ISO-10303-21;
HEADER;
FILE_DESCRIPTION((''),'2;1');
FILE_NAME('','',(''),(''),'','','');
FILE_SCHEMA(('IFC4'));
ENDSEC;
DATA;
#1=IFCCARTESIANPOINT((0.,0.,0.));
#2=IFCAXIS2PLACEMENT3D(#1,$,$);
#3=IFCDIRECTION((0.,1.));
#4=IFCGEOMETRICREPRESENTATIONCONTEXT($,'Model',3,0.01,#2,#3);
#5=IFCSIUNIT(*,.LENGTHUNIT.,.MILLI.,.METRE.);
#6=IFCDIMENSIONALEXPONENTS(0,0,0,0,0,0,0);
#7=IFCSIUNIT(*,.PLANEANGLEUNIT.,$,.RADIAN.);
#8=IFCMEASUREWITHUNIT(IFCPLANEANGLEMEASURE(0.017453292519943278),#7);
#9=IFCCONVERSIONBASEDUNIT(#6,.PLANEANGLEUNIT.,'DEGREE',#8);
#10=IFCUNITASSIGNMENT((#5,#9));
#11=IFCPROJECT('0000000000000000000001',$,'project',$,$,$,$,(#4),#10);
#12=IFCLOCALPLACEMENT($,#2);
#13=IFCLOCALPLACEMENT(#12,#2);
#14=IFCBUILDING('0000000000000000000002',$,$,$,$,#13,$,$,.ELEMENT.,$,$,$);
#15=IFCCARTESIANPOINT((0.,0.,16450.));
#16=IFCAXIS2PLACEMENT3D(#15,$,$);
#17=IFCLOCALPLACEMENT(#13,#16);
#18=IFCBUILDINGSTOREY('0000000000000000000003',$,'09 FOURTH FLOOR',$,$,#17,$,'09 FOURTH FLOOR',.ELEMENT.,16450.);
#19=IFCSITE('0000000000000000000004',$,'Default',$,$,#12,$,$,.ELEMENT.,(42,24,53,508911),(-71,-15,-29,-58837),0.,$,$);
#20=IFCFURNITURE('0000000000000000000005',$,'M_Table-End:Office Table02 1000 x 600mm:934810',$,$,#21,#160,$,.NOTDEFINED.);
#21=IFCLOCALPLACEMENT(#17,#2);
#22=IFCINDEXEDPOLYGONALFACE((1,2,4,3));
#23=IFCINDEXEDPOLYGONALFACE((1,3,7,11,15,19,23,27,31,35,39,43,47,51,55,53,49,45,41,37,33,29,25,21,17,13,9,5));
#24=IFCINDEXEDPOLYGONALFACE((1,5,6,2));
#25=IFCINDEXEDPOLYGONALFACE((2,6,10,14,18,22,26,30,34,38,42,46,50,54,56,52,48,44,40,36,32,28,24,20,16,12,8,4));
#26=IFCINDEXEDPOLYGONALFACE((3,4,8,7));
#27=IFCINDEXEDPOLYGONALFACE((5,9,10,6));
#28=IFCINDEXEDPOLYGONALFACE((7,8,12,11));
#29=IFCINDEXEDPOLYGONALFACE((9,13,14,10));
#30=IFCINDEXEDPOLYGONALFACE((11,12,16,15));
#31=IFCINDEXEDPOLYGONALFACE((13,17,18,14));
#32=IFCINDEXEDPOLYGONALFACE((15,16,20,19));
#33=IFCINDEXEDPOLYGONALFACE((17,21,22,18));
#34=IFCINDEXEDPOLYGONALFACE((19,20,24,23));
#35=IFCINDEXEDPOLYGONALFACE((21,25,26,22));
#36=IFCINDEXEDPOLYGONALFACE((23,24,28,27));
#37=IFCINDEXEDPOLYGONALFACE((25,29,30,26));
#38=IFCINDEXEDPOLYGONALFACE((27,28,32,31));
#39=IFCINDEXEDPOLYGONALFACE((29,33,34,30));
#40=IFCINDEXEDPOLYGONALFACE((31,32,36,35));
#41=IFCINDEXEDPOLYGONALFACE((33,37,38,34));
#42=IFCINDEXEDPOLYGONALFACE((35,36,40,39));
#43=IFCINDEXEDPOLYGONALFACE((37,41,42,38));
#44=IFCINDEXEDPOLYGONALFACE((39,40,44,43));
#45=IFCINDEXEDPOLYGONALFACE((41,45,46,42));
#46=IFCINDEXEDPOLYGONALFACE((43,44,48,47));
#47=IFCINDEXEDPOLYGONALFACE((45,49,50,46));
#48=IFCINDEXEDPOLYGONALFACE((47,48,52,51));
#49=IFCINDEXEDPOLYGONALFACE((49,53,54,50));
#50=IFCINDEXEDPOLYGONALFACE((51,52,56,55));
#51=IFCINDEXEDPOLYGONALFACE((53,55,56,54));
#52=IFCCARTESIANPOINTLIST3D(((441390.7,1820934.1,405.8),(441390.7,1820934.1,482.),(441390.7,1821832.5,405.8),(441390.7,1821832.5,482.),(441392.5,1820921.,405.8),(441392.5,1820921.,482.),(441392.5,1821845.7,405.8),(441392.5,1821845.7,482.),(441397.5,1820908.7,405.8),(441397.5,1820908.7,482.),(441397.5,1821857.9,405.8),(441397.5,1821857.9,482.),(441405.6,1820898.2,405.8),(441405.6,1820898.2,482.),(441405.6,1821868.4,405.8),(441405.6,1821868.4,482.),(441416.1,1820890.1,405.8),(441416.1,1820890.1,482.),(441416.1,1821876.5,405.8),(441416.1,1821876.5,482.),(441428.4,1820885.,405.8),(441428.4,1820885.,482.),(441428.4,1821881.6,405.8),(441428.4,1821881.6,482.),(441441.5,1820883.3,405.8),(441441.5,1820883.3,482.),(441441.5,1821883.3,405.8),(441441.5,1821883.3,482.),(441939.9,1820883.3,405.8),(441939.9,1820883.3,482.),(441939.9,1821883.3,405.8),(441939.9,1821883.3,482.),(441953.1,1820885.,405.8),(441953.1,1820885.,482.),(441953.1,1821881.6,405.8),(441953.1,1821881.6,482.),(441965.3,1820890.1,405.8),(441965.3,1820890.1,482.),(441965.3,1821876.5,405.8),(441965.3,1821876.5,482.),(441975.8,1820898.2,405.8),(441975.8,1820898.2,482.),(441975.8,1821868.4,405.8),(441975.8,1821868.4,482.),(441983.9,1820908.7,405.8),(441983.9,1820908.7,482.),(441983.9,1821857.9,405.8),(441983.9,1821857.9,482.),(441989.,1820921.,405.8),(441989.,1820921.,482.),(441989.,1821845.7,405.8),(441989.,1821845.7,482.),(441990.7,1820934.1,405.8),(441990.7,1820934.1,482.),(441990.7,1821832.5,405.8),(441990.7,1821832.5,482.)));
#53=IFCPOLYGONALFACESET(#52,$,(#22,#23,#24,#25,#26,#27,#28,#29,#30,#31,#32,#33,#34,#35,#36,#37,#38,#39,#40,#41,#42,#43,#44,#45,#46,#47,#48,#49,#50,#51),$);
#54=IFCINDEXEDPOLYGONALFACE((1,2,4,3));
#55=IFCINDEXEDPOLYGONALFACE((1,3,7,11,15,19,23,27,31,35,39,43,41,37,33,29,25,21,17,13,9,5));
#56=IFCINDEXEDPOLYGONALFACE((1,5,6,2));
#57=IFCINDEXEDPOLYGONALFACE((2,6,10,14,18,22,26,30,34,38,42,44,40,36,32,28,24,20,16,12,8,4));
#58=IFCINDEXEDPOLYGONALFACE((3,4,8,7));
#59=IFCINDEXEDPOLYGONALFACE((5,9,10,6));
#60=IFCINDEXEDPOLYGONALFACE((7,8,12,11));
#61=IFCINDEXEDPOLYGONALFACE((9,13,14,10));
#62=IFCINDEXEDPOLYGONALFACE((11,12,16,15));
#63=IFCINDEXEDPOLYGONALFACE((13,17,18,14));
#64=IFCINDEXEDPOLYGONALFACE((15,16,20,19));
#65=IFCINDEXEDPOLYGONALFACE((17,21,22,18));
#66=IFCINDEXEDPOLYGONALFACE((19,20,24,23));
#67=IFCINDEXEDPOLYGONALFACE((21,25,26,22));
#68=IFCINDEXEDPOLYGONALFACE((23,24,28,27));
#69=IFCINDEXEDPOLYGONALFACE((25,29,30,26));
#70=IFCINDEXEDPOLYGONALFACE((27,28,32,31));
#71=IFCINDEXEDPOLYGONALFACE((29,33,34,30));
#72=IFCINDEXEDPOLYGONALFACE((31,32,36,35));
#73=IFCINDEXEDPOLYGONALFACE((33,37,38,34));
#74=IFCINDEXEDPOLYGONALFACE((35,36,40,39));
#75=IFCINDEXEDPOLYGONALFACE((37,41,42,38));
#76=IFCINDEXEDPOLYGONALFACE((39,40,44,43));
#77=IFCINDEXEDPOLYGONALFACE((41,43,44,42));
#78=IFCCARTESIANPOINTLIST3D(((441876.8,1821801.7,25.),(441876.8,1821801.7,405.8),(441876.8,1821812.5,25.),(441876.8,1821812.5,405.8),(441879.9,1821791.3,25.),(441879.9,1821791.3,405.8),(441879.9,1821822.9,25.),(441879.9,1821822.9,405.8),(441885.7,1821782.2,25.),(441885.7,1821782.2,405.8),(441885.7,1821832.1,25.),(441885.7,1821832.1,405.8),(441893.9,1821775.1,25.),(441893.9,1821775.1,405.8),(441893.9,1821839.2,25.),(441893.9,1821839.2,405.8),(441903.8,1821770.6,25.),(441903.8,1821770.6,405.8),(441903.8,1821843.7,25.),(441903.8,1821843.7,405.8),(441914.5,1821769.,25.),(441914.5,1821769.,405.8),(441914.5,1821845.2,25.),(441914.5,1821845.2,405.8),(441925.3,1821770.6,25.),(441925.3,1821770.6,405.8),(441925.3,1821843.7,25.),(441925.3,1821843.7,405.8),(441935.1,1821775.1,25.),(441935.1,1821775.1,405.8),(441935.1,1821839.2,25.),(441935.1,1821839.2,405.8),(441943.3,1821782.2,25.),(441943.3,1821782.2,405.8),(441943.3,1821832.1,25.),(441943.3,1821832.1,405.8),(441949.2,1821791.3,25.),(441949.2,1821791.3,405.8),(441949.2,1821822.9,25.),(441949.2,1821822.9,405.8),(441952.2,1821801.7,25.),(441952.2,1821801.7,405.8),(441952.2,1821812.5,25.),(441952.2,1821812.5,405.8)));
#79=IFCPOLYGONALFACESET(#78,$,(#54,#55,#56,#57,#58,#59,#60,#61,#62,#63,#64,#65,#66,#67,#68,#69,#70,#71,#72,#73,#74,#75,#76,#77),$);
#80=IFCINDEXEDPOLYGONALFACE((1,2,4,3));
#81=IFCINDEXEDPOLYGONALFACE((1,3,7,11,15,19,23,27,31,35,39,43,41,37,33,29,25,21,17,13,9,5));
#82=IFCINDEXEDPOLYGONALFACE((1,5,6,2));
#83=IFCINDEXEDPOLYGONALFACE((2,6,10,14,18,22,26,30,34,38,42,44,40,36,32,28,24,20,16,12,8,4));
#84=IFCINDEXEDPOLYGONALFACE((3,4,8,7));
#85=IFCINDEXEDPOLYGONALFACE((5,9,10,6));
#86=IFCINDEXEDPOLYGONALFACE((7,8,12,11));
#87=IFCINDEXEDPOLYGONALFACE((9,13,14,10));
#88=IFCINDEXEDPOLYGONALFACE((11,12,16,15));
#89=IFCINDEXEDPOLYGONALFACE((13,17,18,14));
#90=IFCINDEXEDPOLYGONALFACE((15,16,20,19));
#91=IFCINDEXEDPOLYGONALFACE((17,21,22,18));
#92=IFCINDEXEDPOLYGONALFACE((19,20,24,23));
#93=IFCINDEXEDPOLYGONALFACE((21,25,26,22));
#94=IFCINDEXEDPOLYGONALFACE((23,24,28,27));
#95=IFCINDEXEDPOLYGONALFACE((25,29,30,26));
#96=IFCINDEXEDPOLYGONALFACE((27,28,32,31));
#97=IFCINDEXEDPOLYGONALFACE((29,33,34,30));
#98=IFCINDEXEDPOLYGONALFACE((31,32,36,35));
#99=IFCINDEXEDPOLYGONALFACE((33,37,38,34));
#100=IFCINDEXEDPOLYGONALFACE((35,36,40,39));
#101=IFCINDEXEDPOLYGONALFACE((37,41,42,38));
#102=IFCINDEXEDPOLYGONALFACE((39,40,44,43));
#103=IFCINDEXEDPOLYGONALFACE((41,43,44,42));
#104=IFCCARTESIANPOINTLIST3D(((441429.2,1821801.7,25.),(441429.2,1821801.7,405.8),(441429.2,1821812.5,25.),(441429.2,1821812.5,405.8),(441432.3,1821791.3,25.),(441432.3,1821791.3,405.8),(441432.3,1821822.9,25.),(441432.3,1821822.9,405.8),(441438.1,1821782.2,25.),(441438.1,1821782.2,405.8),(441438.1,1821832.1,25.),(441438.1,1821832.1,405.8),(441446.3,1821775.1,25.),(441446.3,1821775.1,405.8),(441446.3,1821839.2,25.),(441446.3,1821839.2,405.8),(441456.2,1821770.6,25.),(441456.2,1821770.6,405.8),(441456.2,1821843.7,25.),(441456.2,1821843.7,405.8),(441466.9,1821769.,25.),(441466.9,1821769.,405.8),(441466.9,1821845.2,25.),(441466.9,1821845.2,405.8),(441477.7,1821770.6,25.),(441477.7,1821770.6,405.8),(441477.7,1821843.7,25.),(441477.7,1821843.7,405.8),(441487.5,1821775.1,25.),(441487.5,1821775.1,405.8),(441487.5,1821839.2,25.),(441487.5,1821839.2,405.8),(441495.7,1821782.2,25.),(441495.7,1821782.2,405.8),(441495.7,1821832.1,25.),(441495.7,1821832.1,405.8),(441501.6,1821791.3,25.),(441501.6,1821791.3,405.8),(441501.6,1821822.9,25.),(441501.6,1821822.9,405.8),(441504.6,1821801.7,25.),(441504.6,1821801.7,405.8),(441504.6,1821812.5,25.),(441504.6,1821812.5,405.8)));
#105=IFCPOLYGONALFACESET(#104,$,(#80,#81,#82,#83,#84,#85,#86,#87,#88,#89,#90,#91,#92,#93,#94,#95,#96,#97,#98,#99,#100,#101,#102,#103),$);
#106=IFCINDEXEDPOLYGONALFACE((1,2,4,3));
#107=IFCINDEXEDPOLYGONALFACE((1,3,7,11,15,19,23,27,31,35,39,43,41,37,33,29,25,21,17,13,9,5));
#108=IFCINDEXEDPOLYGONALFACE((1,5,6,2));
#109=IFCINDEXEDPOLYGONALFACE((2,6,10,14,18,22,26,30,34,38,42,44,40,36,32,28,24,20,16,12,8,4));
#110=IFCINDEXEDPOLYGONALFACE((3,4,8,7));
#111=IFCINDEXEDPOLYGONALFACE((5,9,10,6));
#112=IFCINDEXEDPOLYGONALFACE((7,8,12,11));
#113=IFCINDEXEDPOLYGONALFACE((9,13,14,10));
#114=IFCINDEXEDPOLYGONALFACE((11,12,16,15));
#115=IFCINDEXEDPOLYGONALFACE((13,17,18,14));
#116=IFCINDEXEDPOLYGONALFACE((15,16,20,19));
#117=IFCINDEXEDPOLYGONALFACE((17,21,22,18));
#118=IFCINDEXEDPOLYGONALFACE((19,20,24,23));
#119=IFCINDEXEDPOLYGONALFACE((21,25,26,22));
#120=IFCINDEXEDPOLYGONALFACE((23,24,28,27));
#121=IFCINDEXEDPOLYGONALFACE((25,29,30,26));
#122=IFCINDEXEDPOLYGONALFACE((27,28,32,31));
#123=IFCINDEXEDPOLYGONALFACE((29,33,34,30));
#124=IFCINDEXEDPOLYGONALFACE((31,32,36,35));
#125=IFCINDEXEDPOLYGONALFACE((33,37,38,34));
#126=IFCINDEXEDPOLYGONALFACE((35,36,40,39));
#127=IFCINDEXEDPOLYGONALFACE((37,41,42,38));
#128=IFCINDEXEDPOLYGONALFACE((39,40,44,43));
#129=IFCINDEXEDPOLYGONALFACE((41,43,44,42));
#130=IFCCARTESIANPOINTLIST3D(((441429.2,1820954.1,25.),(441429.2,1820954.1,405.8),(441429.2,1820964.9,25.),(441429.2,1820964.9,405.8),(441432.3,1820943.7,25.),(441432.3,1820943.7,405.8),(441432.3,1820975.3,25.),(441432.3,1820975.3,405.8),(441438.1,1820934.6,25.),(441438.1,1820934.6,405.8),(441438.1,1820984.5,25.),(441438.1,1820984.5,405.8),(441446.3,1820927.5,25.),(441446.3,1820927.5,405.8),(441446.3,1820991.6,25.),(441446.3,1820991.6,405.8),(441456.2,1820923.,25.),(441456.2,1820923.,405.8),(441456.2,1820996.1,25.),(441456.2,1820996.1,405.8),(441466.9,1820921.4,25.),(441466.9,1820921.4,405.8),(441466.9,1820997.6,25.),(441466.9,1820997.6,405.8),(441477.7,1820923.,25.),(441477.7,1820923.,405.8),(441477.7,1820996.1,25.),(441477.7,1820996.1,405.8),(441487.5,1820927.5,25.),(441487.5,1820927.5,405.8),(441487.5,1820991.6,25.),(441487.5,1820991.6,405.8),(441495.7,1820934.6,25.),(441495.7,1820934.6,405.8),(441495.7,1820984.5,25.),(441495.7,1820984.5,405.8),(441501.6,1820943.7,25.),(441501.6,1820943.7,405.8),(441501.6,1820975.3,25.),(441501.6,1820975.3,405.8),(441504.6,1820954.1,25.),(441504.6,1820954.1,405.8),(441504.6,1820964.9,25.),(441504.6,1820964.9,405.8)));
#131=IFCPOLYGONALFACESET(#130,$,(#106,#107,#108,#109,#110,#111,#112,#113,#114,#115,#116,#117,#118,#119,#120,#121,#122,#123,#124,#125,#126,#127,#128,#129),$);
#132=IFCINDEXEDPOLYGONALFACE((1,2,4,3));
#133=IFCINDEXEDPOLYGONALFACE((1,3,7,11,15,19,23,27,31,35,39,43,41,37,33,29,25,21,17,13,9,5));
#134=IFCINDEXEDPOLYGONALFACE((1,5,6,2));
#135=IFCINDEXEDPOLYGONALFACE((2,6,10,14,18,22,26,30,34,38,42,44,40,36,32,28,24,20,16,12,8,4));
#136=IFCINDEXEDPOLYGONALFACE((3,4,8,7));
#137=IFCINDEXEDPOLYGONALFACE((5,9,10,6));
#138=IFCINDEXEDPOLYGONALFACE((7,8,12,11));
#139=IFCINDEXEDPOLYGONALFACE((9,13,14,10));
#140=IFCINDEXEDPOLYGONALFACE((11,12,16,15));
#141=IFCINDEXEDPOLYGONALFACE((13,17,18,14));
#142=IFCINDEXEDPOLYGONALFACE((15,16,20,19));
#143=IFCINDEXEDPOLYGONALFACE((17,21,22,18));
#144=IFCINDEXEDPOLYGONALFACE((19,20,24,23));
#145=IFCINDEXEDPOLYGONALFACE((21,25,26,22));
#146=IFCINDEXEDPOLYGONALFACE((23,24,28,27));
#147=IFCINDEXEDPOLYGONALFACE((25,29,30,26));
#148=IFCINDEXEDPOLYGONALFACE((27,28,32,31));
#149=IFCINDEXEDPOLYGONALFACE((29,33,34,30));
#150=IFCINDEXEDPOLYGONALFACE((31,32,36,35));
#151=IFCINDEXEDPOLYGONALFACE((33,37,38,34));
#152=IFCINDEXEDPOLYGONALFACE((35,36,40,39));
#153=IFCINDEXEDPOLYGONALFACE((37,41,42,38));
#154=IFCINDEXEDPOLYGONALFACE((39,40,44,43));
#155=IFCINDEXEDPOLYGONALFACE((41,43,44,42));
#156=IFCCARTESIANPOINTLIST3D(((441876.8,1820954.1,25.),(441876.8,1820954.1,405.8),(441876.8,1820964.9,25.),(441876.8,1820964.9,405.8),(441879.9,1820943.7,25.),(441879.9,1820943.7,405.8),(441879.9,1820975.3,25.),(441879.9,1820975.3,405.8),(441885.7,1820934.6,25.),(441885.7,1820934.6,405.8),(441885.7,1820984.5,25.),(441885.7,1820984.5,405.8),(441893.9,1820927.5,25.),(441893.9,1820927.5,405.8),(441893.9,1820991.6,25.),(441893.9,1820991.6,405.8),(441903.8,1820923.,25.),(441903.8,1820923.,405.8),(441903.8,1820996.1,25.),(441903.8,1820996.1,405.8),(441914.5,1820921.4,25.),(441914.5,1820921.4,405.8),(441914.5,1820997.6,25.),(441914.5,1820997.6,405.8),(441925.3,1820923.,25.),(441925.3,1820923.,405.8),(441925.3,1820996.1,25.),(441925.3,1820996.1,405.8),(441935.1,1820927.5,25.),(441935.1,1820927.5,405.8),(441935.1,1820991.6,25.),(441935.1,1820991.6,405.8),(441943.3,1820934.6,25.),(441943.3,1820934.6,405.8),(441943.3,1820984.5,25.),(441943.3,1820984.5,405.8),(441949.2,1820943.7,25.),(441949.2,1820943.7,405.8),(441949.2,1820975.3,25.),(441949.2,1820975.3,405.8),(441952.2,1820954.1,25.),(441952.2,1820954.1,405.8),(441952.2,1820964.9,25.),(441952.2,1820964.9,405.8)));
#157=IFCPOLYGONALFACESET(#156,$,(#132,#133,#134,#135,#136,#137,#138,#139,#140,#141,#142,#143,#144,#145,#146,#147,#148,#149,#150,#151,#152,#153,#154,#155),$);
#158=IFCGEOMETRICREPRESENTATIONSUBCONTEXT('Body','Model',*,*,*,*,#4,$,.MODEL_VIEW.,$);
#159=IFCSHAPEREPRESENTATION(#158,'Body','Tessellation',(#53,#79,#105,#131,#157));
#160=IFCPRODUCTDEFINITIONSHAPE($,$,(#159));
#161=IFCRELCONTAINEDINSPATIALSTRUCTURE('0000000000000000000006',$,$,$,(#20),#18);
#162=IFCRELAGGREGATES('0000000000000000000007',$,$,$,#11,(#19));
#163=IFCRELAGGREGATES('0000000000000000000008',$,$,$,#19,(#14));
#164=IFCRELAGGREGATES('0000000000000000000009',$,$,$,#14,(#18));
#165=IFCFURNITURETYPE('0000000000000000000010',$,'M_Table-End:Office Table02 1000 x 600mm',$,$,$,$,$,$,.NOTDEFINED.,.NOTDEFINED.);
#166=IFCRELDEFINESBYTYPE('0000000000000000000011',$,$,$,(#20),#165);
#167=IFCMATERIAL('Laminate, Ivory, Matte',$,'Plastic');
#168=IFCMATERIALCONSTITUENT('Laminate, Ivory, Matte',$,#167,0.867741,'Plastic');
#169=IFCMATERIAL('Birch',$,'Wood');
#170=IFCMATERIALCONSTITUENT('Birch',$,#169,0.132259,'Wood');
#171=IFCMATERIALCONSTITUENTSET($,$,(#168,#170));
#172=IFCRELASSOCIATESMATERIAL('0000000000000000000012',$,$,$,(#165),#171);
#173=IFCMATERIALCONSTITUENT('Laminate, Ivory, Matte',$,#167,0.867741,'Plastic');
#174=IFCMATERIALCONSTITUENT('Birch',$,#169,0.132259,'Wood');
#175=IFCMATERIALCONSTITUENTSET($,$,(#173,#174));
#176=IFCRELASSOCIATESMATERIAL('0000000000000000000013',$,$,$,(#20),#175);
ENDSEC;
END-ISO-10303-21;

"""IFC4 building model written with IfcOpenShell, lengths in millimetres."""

from ifc_helpers import new_model, entity, si_unit, converted_unit, direction, frame, origin, place, context, subcontext, project, spatial, line, arc, indexed_curve, outline, extrude, source, transform, mapped, material, constituent, constituent_set, type_object, type_shapes, element, save


model = new_model("IFC4")

# Units and contexts
model_context = context("Model", 3, precision=0.01, world=origin(), true_north=direction((0.0, 1.0)))
body_context = subcontext(model_context, "Body", "Model", "MODEL_VIEW")
ifc_project = project(units=[si_unit("LENGTHUNIT", "METRE", prefix="MILLI"), converted_unit("PLANEANGLEUNIT", "DEGREE", entity("IfcPlaneAngleMeasure", 0.017453292519943278), si_unit("PLANEANGLEUNIT", "RADIAN"), dimensions=[0, 0, 0, 0, 0, 0, 0])], contexts=[model_context])

# Site, building, storey
site_placement = place(None, origin())
site = spatial("IfcSite", under=ifc_project, at=site_placement, Name="Default", CompositionType="ELEMENT", RefLatitude=(42, 24, 53, 508911), RefLongitude=(-71, -15, -29, -58837), RefElevation=0.0)
building_placement = place(site_placement, origin())
building = spatial("IfcBuilding", under=site, at=building_placement, CompositionType="ELEMENT")
storey_placement = place(building_placement, frame((0.0, 0.0, 16450.0)))
storey = spatial("IfcBuildingStorey", under=building, at=storey_placement, Name="09 FOURTH FLOOR", LongName="09 FOURTH FLOOR", CompositionType="ELEMENT", Elevation=16450.0)

# Furniture
ifc_material_1 = material(Name="Laminate, Ivory, Matte", Category="Plastic")
ifc_material_2 = material(Name="Birch", Category="Wood")
ifc_constituent_1 = constituent(ifc_material_1, Name="Laminate, Ivory, Matte", Category="Plastic", fraction=0.867741)
ifc_constituent_2 = constituent(ifc_material_2, Name="Birch", Category="Wood", fraction=0.132259)
ifc_constituent_set_1 = constituent_set(constituents=[ifc_constituent_1, ifc_constituent_2])
ifc_constituent_3 = constituent(ifc_material_1, Name="Laminate, Ivory, Matte", Category="Plastic", fraction=0.867741)
ifc_constituent_4 = constituent(ifc_material_2, Name="Birch", Category="Wood", fraction=0.132259)
ifc_constituent_set_2 = constituent_set(constituents=[ifc_constituent_3, ifc_constituent_4])
furniture_type_1 = type_object("IfcFurnitureType", Name="M_Table-End:Office Table02 1000 x 600mm", AssemblyPlace="NOTDEFINED", PredefinedType="NOTDEFINED", material=ifc_constituent_set_2)
shared_shape_1 = source(origin(), body_context, "Body", "SweptSolid", [
    extrude(outline(indexed_curve([(449.2, -300.0), (485.1, -285.1), (500.0, -249.2), (500.0, 249.2), (485.1, 285.1), (449.2, 300.0), (-449.2, 300.0), (-485.1, 285.1), (-500.0, 249.2), (-500.0, -249.2), (-485.1, -285.1), (-449.2, -300.0)], segments=[arc(1, 2, 3), line(3, 4), arc(4, 5, 6), line(6, 7), arc(7, 8, 9), line(9, 10), arc(10, 11, 12), line(12, 1)], self_intersect=False)), frame((503.7, 152.4, 405.8)), (0.0, 0.0, 1.0), 76.2),
    extrude(outline(indexed_curve([(-38.1, 0.0), (0.0, -38.1), (38.1, 0.0), (0.0, 38.1)], segments=[arc(1, 2, 3), arc(3, 4, 1)], self_intersect=False)), frame((927.5, -71.4, 25.0)), (0.0, 0.0, 1.0), 380.8),
    extrude(outline(indexed_curve([(-38.1, 0.0), (0.0, -38.1), (38.1, 0.0), (0.0, 38.1)], segments=[arc(1, 2, 3), arc(3, 4, 1)], self_intersect=False)), frame((927.5, 376.2, 25.0)), (0.0, 0.0, 1.0), 380.8),
    extrude(outline(indexed_curve([(-38.1, 0.0), (0.0, -38.1), (38.1, 0.0), (0.0, 38.1)], segments=[arc(1, 2, 3), arc(3, 4, 1)], self_intersect=False)), frame((79.9, 376.2, 25.0)), (0.0, 0.0, 1.0), 380.8),
    extrude(outline(indexed_curve([(-38.1, 0.0), (0.0, -38.1), (38.1, 0.0), (0.0, 38.1)], segments=[arc(1, 2, 3), arc(3, 4, 1)], self_intersect=False)), frame((79.9, -71.4, 25.0)), (0.0, 0.0, 1.0), 380.8),
])
type_shapes(furniture_type_1, [shared_shape_1])
furniture_1_placement = place(storey_placement, frame((441843.1, 1820879.6, 0.0), z_axis=(0.0, 0.0, 1.0), x_axis=(0.0, 1.0, 0.0)))
element("IfcFurniture", 1, at=furniture_1_placement, inside=storey, type_object=furniture_type_1, material=ifc_constituent_set_1, Name="M_Table-End:Office Table02 1000 x 600mm:934810", PredefinedType="NOTDEFINED", context=body_context, shape_type="MappedRepresentation", body=[
    mapped(shared_shape_1, transform((0.0, 0.0, 0.0), scale=1.0)),
])

save(model, "model.ifc")
